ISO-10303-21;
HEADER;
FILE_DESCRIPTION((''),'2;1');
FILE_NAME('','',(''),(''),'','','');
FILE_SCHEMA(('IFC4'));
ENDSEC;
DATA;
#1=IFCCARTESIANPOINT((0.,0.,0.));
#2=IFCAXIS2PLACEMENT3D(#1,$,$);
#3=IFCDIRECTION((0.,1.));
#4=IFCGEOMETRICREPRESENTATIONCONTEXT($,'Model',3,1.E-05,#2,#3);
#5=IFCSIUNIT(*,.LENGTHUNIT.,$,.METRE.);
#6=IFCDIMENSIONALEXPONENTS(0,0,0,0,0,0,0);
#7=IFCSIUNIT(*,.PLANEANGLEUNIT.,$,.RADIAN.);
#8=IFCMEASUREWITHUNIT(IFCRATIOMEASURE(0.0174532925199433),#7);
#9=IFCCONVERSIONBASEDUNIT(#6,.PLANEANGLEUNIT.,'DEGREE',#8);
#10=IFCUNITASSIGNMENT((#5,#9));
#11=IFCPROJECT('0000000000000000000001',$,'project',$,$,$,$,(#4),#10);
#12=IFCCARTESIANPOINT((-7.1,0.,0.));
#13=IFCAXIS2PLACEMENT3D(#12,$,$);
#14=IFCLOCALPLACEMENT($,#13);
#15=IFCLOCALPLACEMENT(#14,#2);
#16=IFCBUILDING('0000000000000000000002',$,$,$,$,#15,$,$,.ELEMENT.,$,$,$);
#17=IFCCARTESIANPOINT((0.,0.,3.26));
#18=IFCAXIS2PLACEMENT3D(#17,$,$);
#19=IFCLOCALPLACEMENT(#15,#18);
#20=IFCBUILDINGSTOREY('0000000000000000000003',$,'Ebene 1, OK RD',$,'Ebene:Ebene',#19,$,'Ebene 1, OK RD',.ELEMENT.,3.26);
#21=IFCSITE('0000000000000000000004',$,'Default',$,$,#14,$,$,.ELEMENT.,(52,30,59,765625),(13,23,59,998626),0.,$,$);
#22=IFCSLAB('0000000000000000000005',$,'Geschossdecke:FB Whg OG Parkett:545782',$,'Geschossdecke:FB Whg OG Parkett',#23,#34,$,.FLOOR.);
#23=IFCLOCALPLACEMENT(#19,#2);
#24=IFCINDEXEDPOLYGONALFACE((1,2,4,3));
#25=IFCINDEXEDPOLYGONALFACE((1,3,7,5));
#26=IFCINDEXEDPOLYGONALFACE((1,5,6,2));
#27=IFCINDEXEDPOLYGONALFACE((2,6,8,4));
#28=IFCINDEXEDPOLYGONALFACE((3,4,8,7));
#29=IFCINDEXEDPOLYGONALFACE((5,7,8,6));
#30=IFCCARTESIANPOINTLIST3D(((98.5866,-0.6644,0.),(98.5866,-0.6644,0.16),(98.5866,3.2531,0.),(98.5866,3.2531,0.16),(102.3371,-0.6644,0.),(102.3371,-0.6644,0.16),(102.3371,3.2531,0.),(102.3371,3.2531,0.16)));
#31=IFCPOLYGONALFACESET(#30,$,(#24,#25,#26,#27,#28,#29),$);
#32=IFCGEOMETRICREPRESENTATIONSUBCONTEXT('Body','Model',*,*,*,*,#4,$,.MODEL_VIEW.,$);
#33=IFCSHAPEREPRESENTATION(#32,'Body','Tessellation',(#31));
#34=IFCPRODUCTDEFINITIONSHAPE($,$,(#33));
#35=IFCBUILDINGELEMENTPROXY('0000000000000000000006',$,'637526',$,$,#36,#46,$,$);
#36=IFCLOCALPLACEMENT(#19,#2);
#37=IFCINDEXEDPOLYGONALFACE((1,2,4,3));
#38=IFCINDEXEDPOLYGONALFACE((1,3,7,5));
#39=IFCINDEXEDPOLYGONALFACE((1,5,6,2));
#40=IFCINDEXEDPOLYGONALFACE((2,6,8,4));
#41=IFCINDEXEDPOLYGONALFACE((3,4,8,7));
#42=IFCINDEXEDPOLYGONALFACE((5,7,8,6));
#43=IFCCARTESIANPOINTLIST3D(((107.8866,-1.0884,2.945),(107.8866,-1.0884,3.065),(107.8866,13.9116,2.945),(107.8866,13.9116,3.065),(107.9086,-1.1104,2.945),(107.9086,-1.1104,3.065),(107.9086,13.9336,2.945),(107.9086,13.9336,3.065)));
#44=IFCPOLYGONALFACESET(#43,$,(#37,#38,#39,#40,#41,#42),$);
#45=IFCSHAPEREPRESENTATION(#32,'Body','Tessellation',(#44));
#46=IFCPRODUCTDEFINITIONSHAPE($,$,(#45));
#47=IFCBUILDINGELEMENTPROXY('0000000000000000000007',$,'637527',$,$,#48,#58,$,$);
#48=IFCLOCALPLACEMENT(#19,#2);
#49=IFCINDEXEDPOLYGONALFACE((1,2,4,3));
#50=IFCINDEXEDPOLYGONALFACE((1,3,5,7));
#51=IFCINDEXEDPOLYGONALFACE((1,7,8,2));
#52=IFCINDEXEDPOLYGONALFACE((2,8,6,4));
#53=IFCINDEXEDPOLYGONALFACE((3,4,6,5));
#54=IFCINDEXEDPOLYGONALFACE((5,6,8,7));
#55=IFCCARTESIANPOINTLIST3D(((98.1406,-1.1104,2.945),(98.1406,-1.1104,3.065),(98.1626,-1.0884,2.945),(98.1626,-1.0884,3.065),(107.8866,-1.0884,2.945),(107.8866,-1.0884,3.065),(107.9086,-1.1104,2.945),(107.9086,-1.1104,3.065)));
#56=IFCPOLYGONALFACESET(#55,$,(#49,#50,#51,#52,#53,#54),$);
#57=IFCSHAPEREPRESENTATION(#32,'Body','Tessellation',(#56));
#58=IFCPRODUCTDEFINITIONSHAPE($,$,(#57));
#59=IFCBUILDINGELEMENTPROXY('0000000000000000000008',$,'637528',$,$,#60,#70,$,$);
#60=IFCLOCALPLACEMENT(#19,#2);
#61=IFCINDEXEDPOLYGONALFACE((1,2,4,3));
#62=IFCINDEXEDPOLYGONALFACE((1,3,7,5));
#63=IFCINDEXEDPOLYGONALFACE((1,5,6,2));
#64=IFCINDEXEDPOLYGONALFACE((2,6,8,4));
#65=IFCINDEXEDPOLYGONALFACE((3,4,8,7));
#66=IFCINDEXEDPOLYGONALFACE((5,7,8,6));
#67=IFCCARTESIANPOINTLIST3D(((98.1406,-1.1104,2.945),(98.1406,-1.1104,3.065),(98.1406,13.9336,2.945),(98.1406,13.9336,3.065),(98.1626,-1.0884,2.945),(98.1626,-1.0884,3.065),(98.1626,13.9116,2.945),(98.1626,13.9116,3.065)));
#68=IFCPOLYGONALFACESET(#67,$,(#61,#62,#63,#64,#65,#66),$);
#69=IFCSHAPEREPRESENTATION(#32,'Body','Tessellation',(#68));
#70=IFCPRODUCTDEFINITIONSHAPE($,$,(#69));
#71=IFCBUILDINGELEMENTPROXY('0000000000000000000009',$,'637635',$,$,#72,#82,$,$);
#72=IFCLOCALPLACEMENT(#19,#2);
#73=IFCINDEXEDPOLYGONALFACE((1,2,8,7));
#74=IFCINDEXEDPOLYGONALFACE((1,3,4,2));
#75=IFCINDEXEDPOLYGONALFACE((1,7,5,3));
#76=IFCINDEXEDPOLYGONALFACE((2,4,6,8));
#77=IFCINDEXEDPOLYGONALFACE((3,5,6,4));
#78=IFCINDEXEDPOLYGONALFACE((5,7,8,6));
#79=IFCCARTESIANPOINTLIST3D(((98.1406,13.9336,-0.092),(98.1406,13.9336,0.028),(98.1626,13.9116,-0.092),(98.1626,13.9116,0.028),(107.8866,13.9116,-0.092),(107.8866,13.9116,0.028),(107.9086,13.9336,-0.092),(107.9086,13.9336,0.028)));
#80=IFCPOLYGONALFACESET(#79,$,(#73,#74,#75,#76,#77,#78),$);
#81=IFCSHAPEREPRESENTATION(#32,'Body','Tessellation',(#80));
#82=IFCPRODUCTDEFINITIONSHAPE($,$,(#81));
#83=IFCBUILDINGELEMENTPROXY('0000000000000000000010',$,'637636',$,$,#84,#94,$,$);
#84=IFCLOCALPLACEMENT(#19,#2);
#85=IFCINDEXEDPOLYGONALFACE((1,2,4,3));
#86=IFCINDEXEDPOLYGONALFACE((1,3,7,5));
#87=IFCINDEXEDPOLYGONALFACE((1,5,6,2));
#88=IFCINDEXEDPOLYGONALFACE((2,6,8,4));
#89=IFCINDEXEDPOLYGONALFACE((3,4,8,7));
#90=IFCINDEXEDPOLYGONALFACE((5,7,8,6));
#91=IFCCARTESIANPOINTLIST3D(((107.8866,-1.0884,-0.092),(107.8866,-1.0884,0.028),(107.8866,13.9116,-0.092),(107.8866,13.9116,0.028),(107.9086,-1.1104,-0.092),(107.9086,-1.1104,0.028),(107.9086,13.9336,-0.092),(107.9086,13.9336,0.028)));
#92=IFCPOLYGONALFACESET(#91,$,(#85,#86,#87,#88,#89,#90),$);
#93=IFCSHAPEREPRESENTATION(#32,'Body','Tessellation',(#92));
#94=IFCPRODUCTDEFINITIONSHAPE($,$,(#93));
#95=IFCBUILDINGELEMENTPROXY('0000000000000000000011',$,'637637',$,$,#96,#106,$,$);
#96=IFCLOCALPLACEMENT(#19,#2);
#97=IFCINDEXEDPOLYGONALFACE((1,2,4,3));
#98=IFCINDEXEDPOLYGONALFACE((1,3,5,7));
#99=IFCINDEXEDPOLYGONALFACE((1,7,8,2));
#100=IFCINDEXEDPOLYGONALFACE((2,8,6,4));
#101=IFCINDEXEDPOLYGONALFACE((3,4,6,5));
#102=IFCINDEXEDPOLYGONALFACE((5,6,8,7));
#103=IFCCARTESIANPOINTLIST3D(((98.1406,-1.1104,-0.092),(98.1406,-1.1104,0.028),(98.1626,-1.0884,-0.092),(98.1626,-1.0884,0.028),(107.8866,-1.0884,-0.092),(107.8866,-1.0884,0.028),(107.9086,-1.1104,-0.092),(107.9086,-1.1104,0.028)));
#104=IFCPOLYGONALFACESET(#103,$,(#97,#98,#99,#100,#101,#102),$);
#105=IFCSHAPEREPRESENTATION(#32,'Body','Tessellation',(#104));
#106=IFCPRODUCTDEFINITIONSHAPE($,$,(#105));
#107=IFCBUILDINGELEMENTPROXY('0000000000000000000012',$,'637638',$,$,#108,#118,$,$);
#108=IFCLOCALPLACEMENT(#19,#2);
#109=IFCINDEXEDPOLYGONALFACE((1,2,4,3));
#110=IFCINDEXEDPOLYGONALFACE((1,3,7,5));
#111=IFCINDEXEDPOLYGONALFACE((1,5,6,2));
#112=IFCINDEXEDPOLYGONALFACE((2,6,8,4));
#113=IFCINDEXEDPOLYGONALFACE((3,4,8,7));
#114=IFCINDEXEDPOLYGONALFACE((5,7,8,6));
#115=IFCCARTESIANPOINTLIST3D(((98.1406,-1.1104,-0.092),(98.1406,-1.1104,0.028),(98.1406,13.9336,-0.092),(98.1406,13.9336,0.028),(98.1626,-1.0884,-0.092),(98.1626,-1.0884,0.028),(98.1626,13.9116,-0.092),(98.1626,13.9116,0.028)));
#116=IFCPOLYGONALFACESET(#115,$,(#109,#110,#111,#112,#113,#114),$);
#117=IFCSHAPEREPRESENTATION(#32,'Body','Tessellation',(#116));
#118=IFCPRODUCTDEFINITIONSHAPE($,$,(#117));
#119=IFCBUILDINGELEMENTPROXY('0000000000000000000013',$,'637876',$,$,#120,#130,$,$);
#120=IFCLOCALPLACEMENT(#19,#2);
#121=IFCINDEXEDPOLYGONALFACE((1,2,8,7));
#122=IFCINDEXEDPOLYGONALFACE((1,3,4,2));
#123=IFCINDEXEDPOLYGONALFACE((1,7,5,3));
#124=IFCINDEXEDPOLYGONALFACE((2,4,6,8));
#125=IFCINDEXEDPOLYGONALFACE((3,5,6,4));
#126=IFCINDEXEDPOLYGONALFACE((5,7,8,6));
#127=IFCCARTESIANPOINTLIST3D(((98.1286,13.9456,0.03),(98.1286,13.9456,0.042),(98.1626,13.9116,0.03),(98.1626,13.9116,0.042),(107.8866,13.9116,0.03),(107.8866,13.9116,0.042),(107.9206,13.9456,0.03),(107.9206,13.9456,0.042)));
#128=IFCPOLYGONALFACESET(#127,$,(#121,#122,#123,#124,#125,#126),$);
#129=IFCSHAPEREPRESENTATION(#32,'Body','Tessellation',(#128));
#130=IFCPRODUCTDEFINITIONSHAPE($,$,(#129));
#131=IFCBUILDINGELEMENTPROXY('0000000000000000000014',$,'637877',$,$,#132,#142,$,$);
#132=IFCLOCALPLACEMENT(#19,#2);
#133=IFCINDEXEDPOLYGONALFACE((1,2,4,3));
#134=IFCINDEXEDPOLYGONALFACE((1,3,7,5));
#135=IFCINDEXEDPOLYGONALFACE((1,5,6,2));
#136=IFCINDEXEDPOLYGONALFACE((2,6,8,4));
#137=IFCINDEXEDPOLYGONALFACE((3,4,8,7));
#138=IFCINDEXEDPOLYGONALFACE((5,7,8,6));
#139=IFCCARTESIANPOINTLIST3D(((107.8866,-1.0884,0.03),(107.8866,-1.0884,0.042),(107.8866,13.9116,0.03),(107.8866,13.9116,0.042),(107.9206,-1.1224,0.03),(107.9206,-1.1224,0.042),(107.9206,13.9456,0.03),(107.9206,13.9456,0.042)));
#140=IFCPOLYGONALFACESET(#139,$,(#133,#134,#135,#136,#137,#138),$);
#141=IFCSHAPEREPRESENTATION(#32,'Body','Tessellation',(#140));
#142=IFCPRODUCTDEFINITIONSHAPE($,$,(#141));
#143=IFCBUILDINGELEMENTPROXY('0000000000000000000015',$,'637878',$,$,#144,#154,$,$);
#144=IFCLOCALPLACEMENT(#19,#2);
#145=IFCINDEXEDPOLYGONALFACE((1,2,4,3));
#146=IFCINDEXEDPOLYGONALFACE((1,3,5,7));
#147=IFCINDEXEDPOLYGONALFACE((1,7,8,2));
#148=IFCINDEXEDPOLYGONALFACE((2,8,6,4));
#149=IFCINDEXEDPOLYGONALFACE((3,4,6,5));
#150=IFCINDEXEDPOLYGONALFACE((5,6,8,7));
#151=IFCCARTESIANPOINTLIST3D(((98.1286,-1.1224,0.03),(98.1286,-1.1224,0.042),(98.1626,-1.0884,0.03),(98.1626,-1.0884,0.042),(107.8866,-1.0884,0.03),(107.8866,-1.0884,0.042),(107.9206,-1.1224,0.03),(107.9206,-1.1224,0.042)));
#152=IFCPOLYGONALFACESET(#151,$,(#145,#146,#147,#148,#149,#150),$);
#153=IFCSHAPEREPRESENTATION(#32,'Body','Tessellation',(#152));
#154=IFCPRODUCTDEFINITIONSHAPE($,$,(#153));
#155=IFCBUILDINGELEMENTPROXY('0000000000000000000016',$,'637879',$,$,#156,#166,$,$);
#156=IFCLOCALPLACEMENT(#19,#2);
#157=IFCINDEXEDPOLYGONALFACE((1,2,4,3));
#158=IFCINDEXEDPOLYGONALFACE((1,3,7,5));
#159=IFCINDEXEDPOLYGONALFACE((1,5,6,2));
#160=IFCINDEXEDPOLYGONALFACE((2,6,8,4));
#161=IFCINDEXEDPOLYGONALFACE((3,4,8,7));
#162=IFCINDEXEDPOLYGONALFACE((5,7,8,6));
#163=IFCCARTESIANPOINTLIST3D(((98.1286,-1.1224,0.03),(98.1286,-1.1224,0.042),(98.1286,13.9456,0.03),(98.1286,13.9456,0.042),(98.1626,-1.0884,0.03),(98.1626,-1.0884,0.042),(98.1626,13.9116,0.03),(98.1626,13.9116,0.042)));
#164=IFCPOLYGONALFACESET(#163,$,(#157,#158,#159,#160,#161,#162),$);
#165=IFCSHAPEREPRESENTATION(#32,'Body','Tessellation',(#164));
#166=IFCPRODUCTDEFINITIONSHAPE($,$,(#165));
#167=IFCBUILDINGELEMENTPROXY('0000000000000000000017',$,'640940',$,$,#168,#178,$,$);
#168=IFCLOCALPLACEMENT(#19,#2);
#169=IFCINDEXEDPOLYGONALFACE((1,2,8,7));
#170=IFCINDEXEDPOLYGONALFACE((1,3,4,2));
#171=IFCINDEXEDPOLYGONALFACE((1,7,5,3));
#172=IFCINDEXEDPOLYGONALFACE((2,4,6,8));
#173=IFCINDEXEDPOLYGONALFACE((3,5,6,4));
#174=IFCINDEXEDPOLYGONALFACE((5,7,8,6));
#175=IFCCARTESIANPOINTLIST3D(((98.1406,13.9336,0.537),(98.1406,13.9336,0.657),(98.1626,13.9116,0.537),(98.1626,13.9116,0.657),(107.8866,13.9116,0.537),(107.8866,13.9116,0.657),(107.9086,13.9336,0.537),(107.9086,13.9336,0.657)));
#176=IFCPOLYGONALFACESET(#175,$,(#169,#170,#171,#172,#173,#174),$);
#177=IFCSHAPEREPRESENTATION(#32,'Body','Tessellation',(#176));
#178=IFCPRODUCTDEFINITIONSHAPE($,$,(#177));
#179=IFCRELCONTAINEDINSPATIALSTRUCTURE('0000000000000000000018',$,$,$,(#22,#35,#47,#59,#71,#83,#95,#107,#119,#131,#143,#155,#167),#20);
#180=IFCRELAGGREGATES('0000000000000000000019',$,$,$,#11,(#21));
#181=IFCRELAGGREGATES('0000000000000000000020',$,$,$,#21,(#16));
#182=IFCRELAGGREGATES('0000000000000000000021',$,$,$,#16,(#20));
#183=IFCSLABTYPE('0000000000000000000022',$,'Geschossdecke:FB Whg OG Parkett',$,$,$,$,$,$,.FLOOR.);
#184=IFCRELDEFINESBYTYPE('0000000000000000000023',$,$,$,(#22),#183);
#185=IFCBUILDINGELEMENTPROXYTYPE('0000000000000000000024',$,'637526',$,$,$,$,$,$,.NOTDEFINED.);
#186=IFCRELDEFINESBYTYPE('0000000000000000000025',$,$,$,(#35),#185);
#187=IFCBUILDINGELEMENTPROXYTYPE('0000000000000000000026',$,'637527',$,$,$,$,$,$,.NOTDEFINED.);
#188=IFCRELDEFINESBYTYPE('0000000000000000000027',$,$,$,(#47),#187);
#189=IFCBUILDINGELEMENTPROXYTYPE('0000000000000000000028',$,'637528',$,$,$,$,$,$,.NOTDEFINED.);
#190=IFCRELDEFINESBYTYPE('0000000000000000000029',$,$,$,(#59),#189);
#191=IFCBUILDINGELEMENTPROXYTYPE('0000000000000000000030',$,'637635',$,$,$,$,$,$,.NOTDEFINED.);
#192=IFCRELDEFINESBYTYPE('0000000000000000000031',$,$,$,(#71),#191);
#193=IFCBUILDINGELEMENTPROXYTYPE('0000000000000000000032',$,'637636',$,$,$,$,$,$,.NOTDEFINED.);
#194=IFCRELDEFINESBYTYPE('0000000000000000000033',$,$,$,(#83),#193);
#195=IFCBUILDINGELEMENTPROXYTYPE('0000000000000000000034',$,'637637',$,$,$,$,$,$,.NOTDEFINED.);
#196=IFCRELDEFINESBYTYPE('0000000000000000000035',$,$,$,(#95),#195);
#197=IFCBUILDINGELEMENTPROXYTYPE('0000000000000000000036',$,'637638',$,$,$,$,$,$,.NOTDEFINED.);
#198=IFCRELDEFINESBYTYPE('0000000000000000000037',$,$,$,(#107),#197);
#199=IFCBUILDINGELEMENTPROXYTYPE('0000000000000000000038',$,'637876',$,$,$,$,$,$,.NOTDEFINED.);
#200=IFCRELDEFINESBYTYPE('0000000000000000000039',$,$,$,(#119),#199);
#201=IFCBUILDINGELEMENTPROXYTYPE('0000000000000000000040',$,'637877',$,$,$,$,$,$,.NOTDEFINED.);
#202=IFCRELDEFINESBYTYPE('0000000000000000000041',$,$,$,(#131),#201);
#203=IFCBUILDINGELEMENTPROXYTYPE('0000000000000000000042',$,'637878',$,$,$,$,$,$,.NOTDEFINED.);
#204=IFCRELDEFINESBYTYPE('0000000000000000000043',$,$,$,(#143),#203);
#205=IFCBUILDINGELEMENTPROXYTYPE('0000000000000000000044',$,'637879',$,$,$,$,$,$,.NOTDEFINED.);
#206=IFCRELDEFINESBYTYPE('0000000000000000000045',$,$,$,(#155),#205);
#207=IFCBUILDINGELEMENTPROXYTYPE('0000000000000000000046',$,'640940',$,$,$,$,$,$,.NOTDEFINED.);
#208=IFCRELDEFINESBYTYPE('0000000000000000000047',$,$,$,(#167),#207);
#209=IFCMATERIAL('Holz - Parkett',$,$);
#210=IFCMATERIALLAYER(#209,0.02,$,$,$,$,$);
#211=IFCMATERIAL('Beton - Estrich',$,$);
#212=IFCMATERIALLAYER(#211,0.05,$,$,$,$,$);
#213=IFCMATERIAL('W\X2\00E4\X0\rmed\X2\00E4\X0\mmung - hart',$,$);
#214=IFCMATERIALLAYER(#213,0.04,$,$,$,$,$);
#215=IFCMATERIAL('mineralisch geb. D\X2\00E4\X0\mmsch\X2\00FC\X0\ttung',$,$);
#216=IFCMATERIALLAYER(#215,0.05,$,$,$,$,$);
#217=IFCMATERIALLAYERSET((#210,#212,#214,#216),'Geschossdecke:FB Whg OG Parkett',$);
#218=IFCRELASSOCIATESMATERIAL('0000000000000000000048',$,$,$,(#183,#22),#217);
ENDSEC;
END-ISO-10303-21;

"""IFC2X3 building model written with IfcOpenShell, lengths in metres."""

from ifc_helpers import new_model, entity, si_unit, converted_unit, direction, frame, frame_2d, origin, place, context, subcontext, project, spatial, polyline, rectangle, outline, extrude, material, layer, layer_set, layer_usage, type_object, element, save


model = new_model("IFC2X3")

# Units and contexts
model_context = context("Model", 3, precision=1e-05, world=origin(), true_north=direction((0.0, 1.0)))
body_context = subcontext(model_context, "Body", "Model", "MODEL_VIEW")
ifc_project = project(units=[si_unit("LENGTHUNIT", "METRE"), converted_unit("PLANEANGLEUNIT", "DEGREE", entity("IfcRatioMeasure", 0.0174532925199433), si_unit("PLANEANGLEUNIT", "RADIAN"), dimensions=[0, 0, 0, 0, 0, 0, 0])], contexts=[model_context])

# Site, building, storey
site_placement = place(None, frame((-7.1, 0.0, 0.0)))
site = spatial("IfcSite", under=ifc_project, at=site_placement, Name="Default", CompositionType="ELEMENT", RefLatitude=(52, 30, 59, 765625), RefLongitude=(13, 23, 59, 998626), RefElevation=0.0)
building_placement = place(site_placement, origin())
building = spatial("IfcBuilding", under=site, at=building_placement, CompositionType="ELEMENT")
storey_placement = place(building_placement, frame((0.0, 0.0, 3.26)))
storey = spatial("IfcBuildingStorey", under=building, at=storey_placement, Name="Ebene 1, OK RD", ObjectType="Ebene:Ebene", LongName="Ebene 1, OK RD", CompositionType="ELEMENT", Elevation=3.26)

# Slab
ifc_material_1 = material(Name="Holz - Parkett")
ifc_layer_1 = layer(ifc_material_1, 0.02)
ifc_material_2 = material(Name="Beton - Estrich")
ifc_layer_2 = layer(ifc_material_2, 0.05)
ifc_material_3 = material(Name="Wärmedämmung - hart")
ifc_layer_3 = layer(ifc_material_3, 0.04)
ifc_material_4 = material(Name="mineralisch geb. Dämmschüttung")
ifc_layer_4 = layer(ifc_material_4, 0.05)
ifc_layer_set_1 = layer_set([ifc_layer_1, ifc_layer_2, ifc_layer_3, ifc_layer_4], Name="Geschossdecke:FB Whg OG Parkett")
ifc_layer_usage_1 = layer_usage(ifc_layer_set_1, "AXIS3", "POSITIVE", 0.0)
slab_type_1 = type_object("IfcSlabType", Name="Geschossdecke:FB Whg OG Parkett", PredefinedType="FLOOR", material=ifc_layer_set_1)
slab_1_placement = place(storey_placement, origin())
element("IfcSlab", 1, at=slab_1_placement, inside=storey, type_object=slab_type_1, material=ifc_layer_usage_1, Name="Geschossdecke:FB Whg OG Parkett:545782", ObjectType="Geschossdecke:FB Whg OG Parkett", PredefinedType="FLOOR", context=body_context, shape_type="SweptSolid", body=[
    extrude(rectangle(XDim=3.9175, YDim=3.7505, at=frame_2d((0.0, 0.0), x_axis=(1.0, 0.0))), frame((100.4619, 1.2944, 0.16), z_axis=(0.0, 0.0, -1.0), x_axis=(0.0, 1.0, 0.0)), (0.0, 0.0, 1.0), 0.16),
])

# Building element proxies
building_element_proxy_type_1 = type_object("IfcBuildingElementProxyType", Name="637526", PredefinedType="NOTDEFINED")
proxy_1_placement = place(storey_placement, origin())
element("IfcBuildingElementProxy", 2, at=proxy_1_placement, inside=storey, type_object=building_element_proxy_type_1, Name="637526", context=body_context, shape_type="SweptSolid", body=[
    extrude(outline(polyline([(-7.5, -0.011), (7.5, -0.011), (7.522, 0.011), (-7.522, 0.011), (-7.5, -0.011)])), frame((107.8976, 6.4116, 2.945), z_axis=(0.0, 0.0, 1.0), x_axis=(0.0, -1.0, 0.0)), (0.0, 0.0, 1.0), 0.12),
])
building_element_proxy_type_2 = type_object("IfcBuildingElementProxyType", Name="637527", PredefinedType="NOTDEFINED")
proxy_2_placement = place(storey_placement, origin())
element("IfcBuildingElementProxy", 3, at=proxy_2_placement, inside=storey, type_object=building_element_proxy_type_2, Name="637527", context=body_context, shape_type="SweptSolid", body=[
    extrude(outline(polyline([(-4.862, -0.011), (4.862, -0.011), (4.884, 0.011), (-4.884, 0.011), (-4.862, -0.011)])), frame((103.0246, -1.0994, 2.945), z_axis=(0.0, 0.0, 1.0), x_axis=(-1.0, 0.0, 0.0)), (0.0, 0.0, 1.0), 0.12),
])
building_element_proxy_type_3 = type_object("IfcBuildingElementProxyType", Name="637528", PredefinedType="NOTDEFINED")
proxy_3_placement = place(storey_placement, origin())
element("IfcBuildingElementProxy", 4, at=proxy_3_placement, inside=storey, type_object=building_element_proxy_type_3, Name="637528", context=body_context, shape_type="SweptSolid", body=[
    extrude(outline(polyline([(-7.5, -0.011), (7.5, -0.011), (7.522, 0.011), (-7.522, 0.011), (-7.5, -0.011)])), frame((98.1516, 6.4116, 2.945), z_axis=(0.0, 0.0, 1.0), x_axis=(0.0, 1.0, 0.0)), (0.0, 0.0, 1.0), 0.12),
])
building_element_proxy_type_4 = type_object("IfcBuildingElementProxyType", Name="637635", PredefinedType="NOTDEFINED")
proxy_4_placement = place(storey_placement, origin())
element("IfcBuildingElementProxy", 5, at=proxy_4_placement, inside=storey, type_object=building_element_proxy_type_4, Name="637635", context=body_context, shape_type="SweptSolid", body=[
    extrude(outline(polyline([(-4.862, -0.011), (4.862, -0.011), (4.884, 0.011), (-4.884, 0.011), (-4.862, -0.011)])), frame((103.0246, 13.9226, -0.092)), (0.0, 0.0, 1.0), 0.12),
])
building_element_proxy_type_5 = type_object("IfcBuildingElementProxyType", Name="637636", PredefinedType="NOTDEFINED")
proxy_5_placement = place(storey_placement, origin())
element("IfcBuildingElementProxy", 6, at=proxy_5_placement, inside=storey, type_object=building_element_proxy_type_5, Name="637636", context=body_context, shape_type="SweptSolid", body=[
    extrude(outline(polyline([(-7.5, -0.011), (7.5, -0.011), (7.522, 0.011), (-7.522, 0.011), (-7.5, -0.011)])), frame((107.8976, 6.4116, -0.092), z_axis=(0.0, 0.0, 1.0), x_axis=(0.0, -1.0, 0.0)), (0.0, 0.0, 1.0), 0.12),
])
building_element_proxy_type_6 = type_object("IfcBuildingElementProxyType", Name="637637", PredefinedType="NOTDEFINED")
proxy_6_placement = place(storey_placement, origin())
element("IfcBuildingElementProxy", 7, at=proxy_6_placement, inside=storey, type_object=building_element_proxy_type_6, Name="637637", context=body_context, shape_type="SweptSolid", body=[
    extrude(outline(polyline([(-4.862, -0.011), (4.862, -0.011), (4.884, 0.011), (-4.884, 0.011), (-4.862, -0.011)])), frame((103.0246, -1.0994, -0.092), z_axis=(0.0, 0.0, 1.0), x_axis=(-1.0, 0.0, 0.0)), (0.0, 0.0, 1.0), 0.12),
])
building_element_proxy_type_7 = type_object("IfcBuildingElementProxyType", Name="637638", PredefinedType="NOTDEFINED")
proxy_7_placement = place(storey_placement, origin())
element("IfcBuildingElementProxy", 8, at=proxy_7_placement, inside=storey, type_object=building_element_proxy_type_7, Name="637638", context=body_context, shape_type="SweptSolid", body=[
    extrude(outline(polyline([(-7.5, -0.011), (7.5, -0.011), (7.522, 0.011), (-7.522, 0.011), (-7.5, -0.011)])), frame((98.1516, 6.4116, -0.092), z_axis=(0.0, 0.0, 1.0), x_axis=(0.0, 1.0, 0.0)), (0.0, 0.0, 1.0), 0.12),
])
building_element_proxy_type_8 = type_object("IfcBuildingElementProxyType", Name="637876", PredefinedType="NOTDEFINED")
proxy_8_placement = place(storey_placement, origin())
element("IfcBuildingElementProxy", 9, at=proxy_8_placement, inside=storey, type_object=building_element_proxy_type_8, Name="637876", context=body_context, shape_type="SweptSolid", body=[
    extrude(outline(polyline([(-4.862, -0.017), (4.862, -0.017), (4.896, 0.017), (-4.896, 0.017), (-4.862, -0.017)])), frame((103.0246, 13.9286, 0.03)), (0.0, 0.0, 1.0), 0.012),
])
building_element_proxy_type_9 = type_object("IfcBuildingElementProxyType", Name="637877", PredefinedType="NOTDEFINED")
proxy_9_placement = place(storey_placement, origin())
element("IfcBuildingElementProxy", 10, at=proxy_9_placement, inside=storey, type_object=building_element_proxy_type_9, Name="637877", context=body_context, shape_type="SweptSolid", body=[
    extrude(outline(polyline([(-7.5, -0.017), (7.5, -0.017), (7.534, 0.017), (-7.534, 0.017), (-7.5, -0.017)])), frame((107.9036, 6.4116, 0.03), z_axis=(0.0, 0.0, 1.0), x_axis=(0.0, -1.0, 0.0)), (0.0, 0.0, 1.0), 0.012),
])
building_element_proxy_type_10 = type_object("IfcBuildingElementProxyType", Name="637878", PredefinedType="NOTDEFINED")
proxy_10_placement = place(storey_placement, origin())
element("IfcBuildingElementProxy", 11, at=proxy_10_placement, inside=storey, type_object=building_element_proxy_type_10, Name="637878", context=body_context, shape_type="SweptSolid", body=[
    extrude(outline(polyline([(-4.862, -0.017), (4.862, -0.017), (4.896, 0.017), (-4.896, 0.017), (-4.862, -0.017)])), frame((103.0246, -1.1054, 0.03), z_axis=(0.0, 0.0, 1.0), x_axis=(-1.0, 0.0, 0.0)), (0.0, 0.0, 1.0), 0.012),
])
building_element_proxy_type_11 = type_object("IfcBuildingElementProxyType", Name="637879", PredefinedType="NOTDEFINED")
proxy_11_placement = place(storey_placement, origin())
element("IfcBuildingElementProxy", 12, at=proxy_11_placement, inside=storey, type_object=building_element_proxy_type_11, Name="637879", context=body_context, shape_type="SweptSolid", body=[
    extrude(outline(polyline([(-7.5, -0.017), (7.5, -0.017), (7.534, 0.017), (-7.534, 0.017), (-7.5, -0.017)])), frame((98.1456, 6.4116, 0.03), z_axis=(0.0, 0.0, 1.0), x_axis=(0.0, 1.0, 0.0)), (0.0, 0.0, 1.0), 0.012),
])
building_element_proxy_type_12 = type_object("IfcBuildingElementProxyType", Name="640940", PredefinedType="NOTDEFINED")
proxy_12_placement = place(storey_placement, origin())
element("IfcBuildingElementProxy", 13, at=proxy_12_placement, inside=storey, type_object=building_element_proxy_type_12, Name="640940", context=body_context, shape_type="SweptSolid", body=[
    extrude(outline(polyline([(-4.862, -0.011), (4.862, -0.011), (4.884, 0.011), (-4.884, 0.011), (-4.862, -0.011)])), frame((103.0246, 13.9226, 0.537)), (0.0, 0.0, 1.0), 0.12),
])

save(model, "model.ifc")
